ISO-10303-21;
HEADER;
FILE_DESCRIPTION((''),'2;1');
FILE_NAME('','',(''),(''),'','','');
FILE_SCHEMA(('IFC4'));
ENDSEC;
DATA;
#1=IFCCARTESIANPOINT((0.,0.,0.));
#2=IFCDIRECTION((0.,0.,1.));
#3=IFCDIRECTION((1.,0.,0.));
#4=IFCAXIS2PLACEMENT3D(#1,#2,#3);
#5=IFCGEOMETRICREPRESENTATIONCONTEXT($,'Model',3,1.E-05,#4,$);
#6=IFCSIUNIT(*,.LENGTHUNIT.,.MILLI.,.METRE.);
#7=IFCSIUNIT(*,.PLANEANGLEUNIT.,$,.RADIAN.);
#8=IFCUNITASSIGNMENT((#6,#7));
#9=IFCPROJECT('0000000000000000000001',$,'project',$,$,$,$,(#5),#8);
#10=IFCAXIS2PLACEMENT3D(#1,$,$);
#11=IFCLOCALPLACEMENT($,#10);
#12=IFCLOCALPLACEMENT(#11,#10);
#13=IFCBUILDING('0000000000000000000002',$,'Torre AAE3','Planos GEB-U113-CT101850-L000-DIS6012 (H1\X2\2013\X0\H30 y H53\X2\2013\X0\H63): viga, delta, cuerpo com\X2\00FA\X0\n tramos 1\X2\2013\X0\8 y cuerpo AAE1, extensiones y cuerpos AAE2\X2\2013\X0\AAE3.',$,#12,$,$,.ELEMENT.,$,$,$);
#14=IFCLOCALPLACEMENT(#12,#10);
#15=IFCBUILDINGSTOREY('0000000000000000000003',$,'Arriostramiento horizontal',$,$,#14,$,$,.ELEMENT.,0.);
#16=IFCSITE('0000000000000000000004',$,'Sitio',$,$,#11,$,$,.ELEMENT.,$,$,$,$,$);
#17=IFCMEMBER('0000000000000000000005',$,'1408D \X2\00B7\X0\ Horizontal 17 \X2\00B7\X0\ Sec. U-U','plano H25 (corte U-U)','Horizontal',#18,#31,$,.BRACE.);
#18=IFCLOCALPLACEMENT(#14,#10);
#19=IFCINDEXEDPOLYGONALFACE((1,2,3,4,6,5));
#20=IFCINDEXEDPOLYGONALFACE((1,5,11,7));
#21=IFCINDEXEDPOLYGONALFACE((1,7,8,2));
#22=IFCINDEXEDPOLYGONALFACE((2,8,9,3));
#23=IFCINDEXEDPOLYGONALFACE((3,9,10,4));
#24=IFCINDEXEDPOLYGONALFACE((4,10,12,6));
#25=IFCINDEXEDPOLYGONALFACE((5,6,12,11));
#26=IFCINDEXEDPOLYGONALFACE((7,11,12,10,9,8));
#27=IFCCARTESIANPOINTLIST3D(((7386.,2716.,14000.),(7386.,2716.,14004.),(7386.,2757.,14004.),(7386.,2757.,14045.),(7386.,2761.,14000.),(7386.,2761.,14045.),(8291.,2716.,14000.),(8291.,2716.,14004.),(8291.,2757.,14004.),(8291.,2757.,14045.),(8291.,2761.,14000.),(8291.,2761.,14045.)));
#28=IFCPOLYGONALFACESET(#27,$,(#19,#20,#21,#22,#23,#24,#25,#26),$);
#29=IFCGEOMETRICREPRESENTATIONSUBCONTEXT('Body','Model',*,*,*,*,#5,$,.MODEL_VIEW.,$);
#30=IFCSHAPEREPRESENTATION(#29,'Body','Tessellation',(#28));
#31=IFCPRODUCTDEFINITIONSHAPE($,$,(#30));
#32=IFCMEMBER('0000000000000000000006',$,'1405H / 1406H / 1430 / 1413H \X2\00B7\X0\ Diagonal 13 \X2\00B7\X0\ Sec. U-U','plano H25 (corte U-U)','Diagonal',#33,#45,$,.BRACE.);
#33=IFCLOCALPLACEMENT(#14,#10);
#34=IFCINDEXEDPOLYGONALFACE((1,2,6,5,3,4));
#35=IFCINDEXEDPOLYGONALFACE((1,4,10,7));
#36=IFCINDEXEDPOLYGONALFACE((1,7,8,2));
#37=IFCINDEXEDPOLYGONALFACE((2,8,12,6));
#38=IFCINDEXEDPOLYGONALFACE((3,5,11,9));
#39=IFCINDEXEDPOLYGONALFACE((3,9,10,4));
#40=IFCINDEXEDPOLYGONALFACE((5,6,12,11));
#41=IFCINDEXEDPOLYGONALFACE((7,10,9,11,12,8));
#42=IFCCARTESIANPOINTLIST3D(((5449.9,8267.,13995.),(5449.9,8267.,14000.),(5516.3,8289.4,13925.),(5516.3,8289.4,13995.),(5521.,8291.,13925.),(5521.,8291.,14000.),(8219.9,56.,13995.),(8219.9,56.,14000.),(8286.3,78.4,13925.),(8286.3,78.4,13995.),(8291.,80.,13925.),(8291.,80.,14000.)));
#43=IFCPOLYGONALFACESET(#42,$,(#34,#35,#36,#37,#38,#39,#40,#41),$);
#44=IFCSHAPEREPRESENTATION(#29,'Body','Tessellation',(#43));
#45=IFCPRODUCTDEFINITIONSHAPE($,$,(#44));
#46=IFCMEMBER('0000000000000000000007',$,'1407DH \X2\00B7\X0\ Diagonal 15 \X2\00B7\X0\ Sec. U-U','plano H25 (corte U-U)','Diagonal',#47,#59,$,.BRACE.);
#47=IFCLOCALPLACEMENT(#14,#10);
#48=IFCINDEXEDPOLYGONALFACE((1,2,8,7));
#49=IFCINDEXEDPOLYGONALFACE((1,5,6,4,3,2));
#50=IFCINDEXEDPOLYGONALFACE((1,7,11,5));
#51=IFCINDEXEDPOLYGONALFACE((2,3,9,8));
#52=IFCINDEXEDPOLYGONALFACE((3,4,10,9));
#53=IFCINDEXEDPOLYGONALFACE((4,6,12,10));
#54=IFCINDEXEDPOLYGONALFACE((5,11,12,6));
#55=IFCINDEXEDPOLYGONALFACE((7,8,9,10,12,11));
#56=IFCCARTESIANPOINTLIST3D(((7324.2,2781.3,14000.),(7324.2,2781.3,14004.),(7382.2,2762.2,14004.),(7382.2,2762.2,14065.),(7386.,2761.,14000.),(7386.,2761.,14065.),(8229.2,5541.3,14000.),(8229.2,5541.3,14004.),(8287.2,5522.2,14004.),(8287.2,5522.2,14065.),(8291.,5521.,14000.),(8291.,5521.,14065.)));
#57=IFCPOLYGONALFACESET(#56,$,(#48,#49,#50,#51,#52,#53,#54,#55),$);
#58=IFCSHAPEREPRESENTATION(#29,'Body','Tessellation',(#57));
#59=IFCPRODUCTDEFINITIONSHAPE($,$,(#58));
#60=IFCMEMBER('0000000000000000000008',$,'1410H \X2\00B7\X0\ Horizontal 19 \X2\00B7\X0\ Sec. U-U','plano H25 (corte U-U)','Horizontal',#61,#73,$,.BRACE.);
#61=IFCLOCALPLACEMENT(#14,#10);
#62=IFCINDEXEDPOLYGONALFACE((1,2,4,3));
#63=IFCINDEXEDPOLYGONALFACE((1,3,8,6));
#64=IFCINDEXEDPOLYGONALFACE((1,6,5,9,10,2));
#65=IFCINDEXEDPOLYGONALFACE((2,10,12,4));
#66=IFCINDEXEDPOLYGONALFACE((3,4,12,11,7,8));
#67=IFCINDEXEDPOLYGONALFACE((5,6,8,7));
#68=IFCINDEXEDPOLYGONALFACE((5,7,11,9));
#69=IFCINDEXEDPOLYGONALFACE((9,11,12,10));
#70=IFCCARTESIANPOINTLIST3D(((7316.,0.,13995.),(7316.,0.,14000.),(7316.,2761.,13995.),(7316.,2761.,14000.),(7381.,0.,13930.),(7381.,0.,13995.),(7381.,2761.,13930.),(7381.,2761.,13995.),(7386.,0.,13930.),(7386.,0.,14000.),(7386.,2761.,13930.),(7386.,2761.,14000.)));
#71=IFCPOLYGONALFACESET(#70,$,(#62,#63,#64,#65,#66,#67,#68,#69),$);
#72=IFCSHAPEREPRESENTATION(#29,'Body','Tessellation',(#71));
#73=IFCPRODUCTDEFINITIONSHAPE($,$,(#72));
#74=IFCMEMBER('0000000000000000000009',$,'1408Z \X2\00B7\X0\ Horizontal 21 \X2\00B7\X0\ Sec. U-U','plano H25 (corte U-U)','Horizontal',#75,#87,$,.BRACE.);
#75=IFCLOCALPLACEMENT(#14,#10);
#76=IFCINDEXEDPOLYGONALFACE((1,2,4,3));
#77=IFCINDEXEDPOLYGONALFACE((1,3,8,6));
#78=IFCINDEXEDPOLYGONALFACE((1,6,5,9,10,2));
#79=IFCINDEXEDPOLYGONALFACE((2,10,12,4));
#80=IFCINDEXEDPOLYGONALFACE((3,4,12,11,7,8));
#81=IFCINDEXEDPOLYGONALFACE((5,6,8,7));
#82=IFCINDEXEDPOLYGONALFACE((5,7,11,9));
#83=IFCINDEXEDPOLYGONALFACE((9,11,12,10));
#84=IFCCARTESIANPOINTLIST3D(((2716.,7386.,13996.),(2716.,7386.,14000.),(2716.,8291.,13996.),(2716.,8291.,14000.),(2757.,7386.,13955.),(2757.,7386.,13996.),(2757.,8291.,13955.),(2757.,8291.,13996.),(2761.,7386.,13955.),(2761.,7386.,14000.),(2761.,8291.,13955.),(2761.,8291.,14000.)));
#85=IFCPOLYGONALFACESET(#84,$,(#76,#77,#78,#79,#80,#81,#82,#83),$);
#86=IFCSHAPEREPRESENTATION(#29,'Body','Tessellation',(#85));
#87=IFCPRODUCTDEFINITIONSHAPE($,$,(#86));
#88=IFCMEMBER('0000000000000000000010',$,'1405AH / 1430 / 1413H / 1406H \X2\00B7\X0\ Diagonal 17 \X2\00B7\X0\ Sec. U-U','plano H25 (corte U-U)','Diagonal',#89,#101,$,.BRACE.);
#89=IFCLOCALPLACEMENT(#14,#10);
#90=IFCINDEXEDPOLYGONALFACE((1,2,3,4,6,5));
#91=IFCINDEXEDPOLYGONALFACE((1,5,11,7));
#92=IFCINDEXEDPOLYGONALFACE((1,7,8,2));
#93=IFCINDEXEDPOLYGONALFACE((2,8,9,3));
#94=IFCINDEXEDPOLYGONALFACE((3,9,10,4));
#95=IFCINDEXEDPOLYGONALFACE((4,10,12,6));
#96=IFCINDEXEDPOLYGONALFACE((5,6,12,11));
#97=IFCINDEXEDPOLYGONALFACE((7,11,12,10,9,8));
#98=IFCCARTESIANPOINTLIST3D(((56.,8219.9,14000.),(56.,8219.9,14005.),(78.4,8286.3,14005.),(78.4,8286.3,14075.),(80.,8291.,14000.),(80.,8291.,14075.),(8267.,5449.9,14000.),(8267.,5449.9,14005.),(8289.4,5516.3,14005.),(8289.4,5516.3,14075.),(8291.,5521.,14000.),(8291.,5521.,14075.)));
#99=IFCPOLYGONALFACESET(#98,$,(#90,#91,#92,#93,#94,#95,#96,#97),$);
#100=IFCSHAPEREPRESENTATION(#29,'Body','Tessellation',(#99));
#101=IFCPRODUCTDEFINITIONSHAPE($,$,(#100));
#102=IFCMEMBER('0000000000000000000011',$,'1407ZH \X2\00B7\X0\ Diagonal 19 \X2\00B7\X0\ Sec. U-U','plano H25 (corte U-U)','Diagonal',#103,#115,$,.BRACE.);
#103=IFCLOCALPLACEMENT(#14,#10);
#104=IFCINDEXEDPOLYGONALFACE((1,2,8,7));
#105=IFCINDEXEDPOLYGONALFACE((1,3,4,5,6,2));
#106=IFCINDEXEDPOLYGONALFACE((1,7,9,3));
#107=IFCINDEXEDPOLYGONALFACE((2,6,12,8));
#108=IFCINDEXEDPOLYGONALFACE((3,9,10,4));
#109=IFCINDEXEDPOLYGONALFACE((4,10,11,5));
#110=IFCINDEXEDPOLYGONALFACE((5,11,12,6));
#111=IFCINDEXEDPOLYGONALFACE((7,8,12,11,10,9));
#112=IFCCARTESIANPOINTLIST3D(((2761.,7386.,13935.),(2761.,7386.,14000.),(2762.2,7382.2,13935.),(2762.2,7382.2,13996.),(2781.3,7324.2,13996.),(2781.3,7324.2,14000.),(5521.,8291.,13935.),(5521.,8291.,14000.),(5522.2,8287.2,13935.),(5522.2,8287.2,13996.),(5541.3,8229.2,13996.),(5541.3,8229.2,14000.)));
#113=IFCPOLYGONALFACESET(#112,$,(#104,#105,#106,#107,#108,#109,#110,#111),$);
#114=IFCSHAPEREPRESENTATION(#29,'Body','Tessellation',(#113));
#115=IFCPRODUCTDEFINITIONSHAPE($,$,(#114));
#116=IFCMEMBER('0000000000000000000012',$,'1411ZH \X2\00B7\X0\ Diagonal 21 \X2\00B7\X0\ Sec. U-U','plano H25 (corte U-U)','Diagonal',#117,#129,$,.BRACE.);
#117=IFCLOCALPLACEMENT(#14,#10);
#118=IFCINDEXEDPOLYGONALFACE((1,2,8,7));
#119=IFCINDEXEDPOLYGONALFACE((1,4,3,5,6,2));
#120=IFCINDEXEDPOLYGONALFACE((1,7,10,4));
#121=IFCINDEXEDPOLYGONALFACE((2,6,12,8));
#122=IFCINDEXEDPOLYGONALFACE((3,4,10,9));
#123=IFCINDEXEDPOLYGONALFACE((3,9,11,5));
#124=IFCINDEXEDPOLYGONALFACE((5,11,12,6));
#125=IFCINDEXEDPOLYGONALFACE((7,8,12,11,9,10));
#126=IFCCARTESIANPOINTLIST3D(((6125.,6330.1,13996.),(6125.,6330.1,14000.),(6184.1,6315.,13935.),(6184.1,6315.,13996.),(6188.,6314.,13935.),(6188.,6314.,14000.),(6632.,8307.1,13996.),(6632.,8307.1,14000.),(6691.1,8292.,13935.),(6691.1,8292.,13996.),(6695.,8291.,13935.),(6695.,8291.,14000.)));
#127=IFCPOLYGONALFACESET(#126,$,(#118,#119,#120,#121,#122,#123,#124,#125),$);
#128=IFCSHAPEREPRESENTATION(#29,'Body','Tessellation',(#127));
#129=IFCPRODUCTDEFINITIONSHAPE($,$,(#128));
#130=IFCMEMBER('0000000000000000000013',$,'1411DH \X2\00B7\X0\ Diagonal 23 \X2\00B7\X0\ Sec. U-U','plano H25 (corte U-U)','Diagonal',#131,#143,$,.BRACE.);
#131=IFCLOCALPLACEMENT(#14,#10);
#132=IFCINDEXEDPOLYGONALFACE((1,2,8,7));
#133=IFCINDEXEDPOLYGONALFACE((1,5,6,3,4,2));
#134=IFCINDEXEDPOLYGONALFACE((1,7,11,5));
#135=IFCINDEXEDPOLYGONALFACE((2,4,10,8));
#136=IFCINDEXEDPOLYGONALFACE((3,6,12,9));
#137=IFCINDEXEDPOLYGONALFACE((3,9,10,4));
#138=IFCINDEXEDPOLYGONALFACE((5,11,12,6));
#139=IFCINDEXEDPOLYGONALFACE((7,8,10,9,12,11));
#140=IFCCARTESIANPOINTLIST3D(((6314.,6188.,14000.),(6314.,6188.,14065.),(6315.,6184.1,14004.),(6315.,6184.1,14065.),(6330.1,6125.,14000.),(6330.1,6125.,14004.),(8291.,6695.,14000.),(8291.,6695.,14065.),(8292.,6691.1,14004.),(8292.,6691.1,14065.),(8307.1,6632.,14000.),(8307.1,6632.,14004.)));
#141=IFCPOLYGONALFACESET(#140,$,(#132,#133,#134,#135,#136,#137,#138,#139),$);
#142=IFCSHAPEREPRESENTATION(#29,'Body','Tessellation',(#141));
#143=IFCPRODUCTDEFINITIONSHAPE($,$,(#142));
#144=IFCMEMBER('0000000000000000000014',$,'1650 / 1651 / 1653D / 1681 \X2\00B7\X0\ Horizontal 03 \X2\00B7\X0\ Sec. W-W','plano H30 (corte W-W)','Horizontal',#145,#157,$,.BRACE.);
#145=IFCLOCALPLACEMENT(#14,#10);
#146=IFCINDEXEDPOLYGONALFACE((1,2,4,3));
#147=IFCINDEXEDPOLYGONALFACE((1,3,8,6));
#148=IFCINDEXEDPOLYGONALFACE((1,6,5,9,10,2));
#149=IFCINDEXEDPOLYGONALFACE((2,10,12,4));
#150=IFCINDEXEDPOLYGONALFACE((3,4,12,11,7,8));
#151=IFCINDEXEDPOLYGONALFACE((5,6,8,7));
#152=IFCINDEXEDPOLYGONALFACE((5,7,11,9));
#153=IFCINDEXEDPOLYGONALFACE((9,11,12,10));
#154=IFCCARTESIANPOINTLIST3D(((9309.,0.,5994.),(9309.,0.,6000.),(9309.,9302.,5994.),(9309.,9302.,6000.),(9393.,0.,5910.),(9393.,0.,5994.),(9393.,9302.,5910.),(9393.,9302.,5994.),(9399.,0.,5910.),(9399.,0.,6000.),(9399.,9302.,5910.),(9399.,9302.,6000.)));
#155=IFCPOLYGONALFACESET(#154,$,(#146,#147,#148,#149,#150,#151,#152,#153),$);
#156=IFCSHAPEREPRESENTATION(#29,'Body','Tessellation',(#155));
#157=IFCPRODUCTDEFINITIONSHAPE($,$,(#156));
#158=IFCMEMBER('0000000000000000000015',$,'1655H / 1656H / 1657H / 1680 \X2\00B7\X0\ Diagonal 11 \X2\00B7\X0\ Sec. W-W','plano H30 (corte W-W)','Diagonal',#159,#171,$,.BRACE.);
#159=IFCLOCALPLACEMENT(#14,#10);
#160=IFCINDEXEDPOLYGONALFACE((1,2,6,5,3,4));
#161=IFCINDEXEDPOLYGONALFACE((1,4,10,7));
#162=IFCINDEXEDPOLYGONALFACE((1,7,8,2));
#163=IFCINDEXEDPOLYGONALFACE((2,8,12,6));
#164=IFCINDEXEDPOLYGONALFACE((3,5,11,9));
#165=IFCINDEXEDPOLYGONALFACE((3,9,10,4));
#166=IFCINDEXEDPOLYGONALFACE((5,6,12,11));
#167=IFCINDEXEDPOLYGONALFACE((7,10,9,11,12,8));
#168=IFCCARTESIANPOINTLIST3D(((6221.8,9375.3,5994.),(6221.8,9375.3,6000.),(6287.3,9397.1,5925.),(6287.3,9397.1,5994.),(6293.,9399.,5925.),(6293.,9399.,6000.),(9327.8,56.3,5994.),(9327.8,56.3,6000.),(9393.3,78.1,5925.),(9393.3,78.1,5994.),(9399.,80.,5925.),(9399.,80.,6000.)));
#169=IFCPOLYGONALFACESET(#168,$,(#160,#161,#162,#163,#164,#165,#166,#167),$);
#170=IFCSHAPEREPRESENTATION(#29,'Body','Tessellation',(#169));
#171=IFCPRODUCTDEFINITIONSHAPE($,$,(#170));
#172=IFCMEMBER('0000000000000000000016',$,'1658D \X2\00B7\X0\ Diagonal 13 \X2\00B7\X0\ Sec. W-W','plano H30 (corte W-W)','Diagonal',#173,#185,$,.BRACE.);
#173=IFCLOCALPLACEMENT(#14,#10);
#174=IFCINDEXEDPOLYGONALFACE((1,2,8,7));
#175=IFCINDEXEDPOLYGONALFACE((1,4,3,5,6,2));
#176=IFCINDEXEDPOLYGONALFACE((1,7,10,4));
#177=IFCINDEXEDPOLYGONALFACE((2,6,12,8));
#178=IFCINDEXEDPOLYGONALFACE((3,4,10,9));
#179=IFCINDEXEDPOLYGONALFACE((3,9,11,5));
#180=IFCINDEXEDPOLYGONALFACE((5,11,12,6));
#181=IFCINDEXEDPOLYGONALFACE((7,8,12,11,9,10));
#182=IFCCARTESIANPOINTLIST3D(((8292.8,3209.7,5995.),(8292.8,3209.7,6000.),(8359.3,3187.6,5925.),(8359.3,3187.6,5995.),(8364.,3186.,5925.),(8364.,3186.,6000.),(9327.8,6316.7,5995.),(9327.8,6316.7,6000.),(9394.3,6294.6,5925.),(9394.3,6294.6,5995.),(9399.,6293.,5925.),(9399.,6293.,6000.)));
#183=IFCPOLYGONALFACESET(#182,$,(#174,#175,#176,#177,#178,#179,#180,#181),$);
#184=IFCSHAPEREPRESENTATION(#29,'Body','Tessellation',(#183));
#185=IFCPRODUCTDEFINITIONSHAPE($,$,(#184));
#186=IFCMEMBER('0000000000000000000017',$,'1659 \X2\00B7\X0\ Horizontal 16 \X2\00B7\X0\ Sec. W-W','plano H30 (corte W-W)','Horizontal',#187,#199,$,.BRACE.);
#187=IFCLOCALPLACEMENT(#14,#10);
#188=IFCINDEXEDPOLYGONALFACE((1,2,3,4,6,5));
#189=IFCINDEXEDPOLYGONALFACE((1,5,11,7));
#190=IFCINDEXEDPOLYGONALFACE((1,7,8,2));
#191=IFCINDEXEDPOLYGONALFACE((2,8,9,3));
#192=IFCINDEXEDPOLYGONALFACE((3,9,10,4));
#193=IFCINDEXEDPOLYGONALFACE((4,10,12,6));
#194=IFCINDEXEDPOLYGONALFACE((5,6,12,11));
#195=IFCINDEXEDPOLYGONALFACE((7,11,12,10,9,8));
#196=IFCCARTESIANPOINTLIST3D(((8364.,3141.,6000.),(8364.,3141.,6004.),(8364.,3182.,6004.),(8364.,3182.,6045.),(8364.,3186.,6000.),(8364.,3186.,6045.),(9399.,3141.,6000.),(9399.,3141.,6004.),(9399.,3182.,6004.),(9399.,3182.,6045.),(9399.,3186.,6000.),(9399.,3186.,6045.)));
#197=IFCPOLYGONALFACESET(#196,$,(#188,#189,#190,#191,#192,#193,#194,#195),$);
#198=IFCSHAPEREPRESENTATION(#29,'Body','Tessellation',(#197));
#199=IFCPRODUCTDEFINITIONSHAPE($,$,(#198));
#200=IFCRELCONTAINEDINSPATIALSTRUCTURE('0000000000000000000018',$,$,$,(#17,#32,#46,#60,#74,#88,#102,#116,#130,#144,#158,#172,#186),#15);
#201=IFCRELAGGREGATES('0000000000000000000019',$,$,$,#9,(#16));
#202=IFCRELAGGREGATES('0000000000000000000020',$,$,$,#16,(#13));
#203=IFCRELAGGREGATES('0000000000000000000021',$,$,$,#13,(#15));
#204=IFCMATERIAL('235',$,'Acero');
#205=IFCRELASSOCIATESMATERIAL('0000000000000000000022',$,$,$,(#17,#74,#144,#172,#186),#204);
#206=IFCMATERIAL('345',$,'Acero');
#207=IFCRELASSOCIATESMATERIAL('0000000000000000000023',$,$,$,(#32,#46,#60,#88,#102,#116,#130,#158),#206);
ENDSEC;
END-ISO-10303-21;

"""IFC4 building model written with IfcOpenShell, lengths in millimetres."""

from ifc_helpers import new_model, si_unit, frame, frame_2d, origin, origin_with_axes, place, context, subcontext, project, spatial, l_section, extrude, material, element, save


model = new_model("IFC4")

# Units and contexts
model_context = context("Model", 3, precision=1e-05, world=origin_with_axes())
body_context = subcontext(model_context, "Body", "Model", "MODEL_VIEW")
ifc_project = project(units=[si_unit("LENGTHUNIT", "METRE", prefix="MILLI"), si_unit("PLANEANGLEUNIT", "RADIAN")], contexts=[model_context])

# Site, building, storey
site_placement = place(None, origin())
site = spatial("IfcSite", under=ifc_project, at=site_placement, Name="Sitio", CompositionType="ELEMENT")
building_placement = place(site_placement, origin())
building = spatial("IfcBuilding", under=site, at=building_placement, Name="Torre AAE3", Description="Planos GEB-U113-CT101850-L000-DIS6012 (H1–H30 y H53–H63): viga, delta, cuerpo común tramos 1–8 y cuerpo AAE1, extensiones y cuerpos AAE2–AAE3.", CompositionType="ELEMENT")
storey_placement = place(building_placement, origin())
storey = spatial("IfcBuildingStorey", under=building, at=storey_placement, Name="Arriostramiento horizontal", CompositionType="ELEMENT", Elevation=0.0)

# Members
ifc_material_1 = material(Name="235", Category="Acero")
ifc_material_2 = material(Name="345", Category="Acero")
member_1_placement = place(storey_placement, frame((8291.0, 2761.0, 14000.0), z_axis=(-1.0, 0.0, 0.0), x_axis=(0.0, -1.0, 0.0)))
element("IfcMember", 1, at=member_1_placement, inside=storey, material=ifc_material_1, Name="1408D · Horizontal 17 · Sec. U-U", Description="plano H25 (corte U-U)", ObjectType="Horizontal", PredefinedType="BRACE", context=body_context, shape_type="SweptSolid", body=[
    extrude(l_section(Depth=45.0, Width=45.0, Thickness=4.0, at=frame_2d((22.5, 22.5))), None, (0.0, 0.0, 1.0), 905.0),
])
member_2_placement = place(storey_placement, frame((5521.0, 8291.0, 14000.0), z_axis=(0.319653, -0.947535, 0.0), x_axis=(-0.947535, -0.319653, 0.0)))
element("IfcMember", 2, at=member_2_placement, inside=storey, material=ifc_material_2, Name="1405H / 1406H / 1430 / 1413H · Diagonal 13 · Sec. U-U", Description="plano H25 (corte U-U)", ObjectType="Diagonal", PredefinedType="BRACE", context=body_context, shape_type="SweptSolid", body=[
    extrude(l_section(Depth=75.0, Width=75.0, Thickness=5.0, at=frame_2d((37.5, 37.5))), None, (0.0, 0.0, 1.0), 8665.6),
])
member_3_placement = place(storey_placement, frame((7386.0, 2761.0, 14000.0), z_axis=(0.311576, 0.950221, 0.0), x_axis=(-0.950221, 0.311576, 0.0)))
element("IfcMember", 3, at=member_3_placement, inside=storey, material=ifc_material_2, Name="1407DH · Diagonal 15 · Sec. U-U", Description="plano H25 (corte U-U)", ObjectType="Diagonal", PredefinedType="BRACE", context=body_context, shape_type="SweptSolid", body=[
    extrude(l_section(Depth=65.0, Width=65.0, Thickness=4.0, at=frame_2d((32.5, 32.5))), None, (0.0, 0.0, 1.0), 2904.6),
])
member_4_placement = place(storey_placement, frame((7386.0, 2761.0, 14000.0), z_axis=(0.0, -1.0, 0.0), x_axis=(-1.0, 0.0, 0.0)))
element("IfcMember", 4, at=member_4_placement, inside=storey, material=ifc_material_2, Name="1410H · Horizontal 19 · Sec. U-U", Description="plano H25 (corte U-U)", ObjectType="Horizontal", PredefinedType="BRACE", context=body_context, shape_type="SweptSolid", body=[
    extrude(l_section(Depth=70.0, Width=70.0, Thickness=5.0, at=frame_2d((35.0, 35.0))), None, (0.0, 0.0, 1.0), 2761.0),
])
member_5_placement = place(storey_placement, frame((2761.0, 8291.0, 14000.0), z_axis=(0.0, -1.0, 0.0), x_axis=(-1.0, 0.0, 0.0)))
element("IfcMember", 5, at=member_5_placement, inside=storey, material=ifc_material_1, Name="1408Z · Horizontal 21 · Sec. U-U", Description="plano H25 (corte U-U)", ObjectType="Horizontal", PredefinedType="BRACE", context=body_context, shape_type="SweptSolid", body=[
    extrude(l_section(Depth=45.0, Width=45.0, Thickness=4.0, at=frame_2d((22.5, 22.5))), None, (0.0, 0.0, 1.0), 905.0),
])
member_6_placement = place(storey_placement, frame((8291.0, 5521.0, 14000.0), z_axis=(-0.947535, 0.319653, 0.0), x_axis=(-0.319653, -0.947535, 0.0)))
element("IfcMember", 6, at=member_6_placement, inside=storey, material=ifc_material_2, Name="1405AH / 1430 / 1413H / 1406H · Diagonal 17 · Sec. U-U", Description="plano H25 (corte U-U)", ObjectType="Diagonal", PredefinedType="BRACE", context=body_context, shape_type="SweptSolid", body=[
    extrude(l_section(Depth=75.0, Width=75.0, Thickness=5.0, at=frame_2d((37.5, 37.5))), None, (0.0, 0.0, 1.0), 8665.6),
])
member_7_placement = place(storey_placement, frame((2761.0, 7386.0, 14000.0), z_axis=(0.950221, 0.311576, 0.0), x_axis=(0.311576, -0.950221, 0.0)))
element("IfcMember", 7, at=member_7_placement, inside=storey, material=ifc_material_2, Name="1407ZH · Diagonal 19 · Sec. U-U", Description="plano H25 (corte U-U)", ObjectType="Diagonal", PredefinedType="BRACE", context=body_context, shape_type="SweptSolid", body=[
    extrude(l_section(Depth=65.0, Width=65.0, Thickness=4.0, at=frame_2d((32.5, 32.5))), None, (0.0, 0.0, 1.0), 2904.6),
])
for number, where, z_axis, x_axis, name in (
    (8, (6695.0, 8291.0, 14000.0), (-0.248411, -0.968655, 0.0), (-0.968655, 0.248411, 0.0), "1411ZH · Diagonal 21 · Sec. U-U"),
    (9, (8291.0, 6695.0, 14000.0), (-0.968655, -0.248411, 0.0), (0.248411, -0.968655, 0.0), "1411DH · Diagonal 23 · Sec. U-U"),
):
    element("IfcMember", number, at=place(storey_placement, frame(where, z_axis=z_axis, x_axis=x_axis)), inside=storey, material=ifc_material_2, Name=name, Description="plano H25 (corte U-U)", ObjectType="Diagonal", PredefinedType="BRACE", context=body_context, shape_type="SweptSolid", body=[
        extrude(l_section(Depth=65.0, Width=65.0, Thickness=4.0, at=frame_2d((32.5, 32.5))), None, (0.0, 0.0, 1.0), 2041.0),
    ])
member_8_placement = place(storey_placement, frame((9399.0, 9302.0, 6000.0), z_axis=(0.0, -1.0, 0.0), x_axis=(-1.0, 0.0, 0.0)))
element("IfcMember", 10, at=member_8_placement, inside=storey, material=ifc_material_1, Name="1650 / 1651 / 1653D / 1681 · Horizontal 03 · Sec. W-W", Description="plano H30 (corte W-W)", ObjectType="Horizontal", PredefinedType="BRACE", context=body_context, shape_type="SweptSolid", body=[
    extrude(l_section(Depth=90.0, Width=90.0, Thickness=6.0, at=frame_2d((45.0, 45.0))), None, (0.0, 0.0, 1.0), 9302.0),
])
member_9_placement = place(storey_placement, frame((6293.0, 9399.0, 6000.0), z_axis=(0.316197, -0.948693, 0.0), x_axis=(-0.948693, -0.316197, 0.0)))
element("IfcMember", 11, at=member_9_placement, inside=storey, material=ifc_material_2, Name="1655H / 1656H / 1657H / 1680 · Diagonal 11 · Sec. W-W", Description="plano H30 (corte W-W)", ObjectType="Diagonal", PredefinedType="BRACE", context=body_context, shape_type="SweptSolid", body=[
    extrude(l_section(Depth=75.0, Width=75.0, Thickness=6.0, at=frame_2d((37.5, 37.5))), None, (0.0, 0.0, 1.0), 9823.0),
])
member_10_placement = place(storey_placement, frame((9399.0, 6293.0, 6000.0), z_axis=(-0.316045, -0.948744, 0.0), x_axis=(-0.948744, 0.316045, 0.0)))
element("IfcMember", 12, at=member_10_placement, inside=storey, material=ifc_material_1, Name="1658D · Diagonal 13 · Sec. W-W", Description="plano H30 (corte W-W)", ObjectType="Diagonal", PredefinedType="BRACE", context=body_context, shape_type="SweptSolid", body=[
    extrude(l_section(Depth=75.0, Width=75.0, Thickness=5.0, at=frame_2d((37.5, 37.5))), None, (0.0, 0.0, 1.0), 3274.9),
])
for number, where, z_axis, x_axis, name in (
    (13, (9399.0, 3186.0, 6000.0), (-1.0, 0.0, 0.0), (0.0, -1.0, 0.0), "1659 · Horizontal 16 · Sec. W-W"),
):
    element("IfcMember", number, at=place(storey_placement, frame(where, z_axis=z_axis, x_axis=x_axis)), inside=storey, material=ifc_material_1, Name=name, Description="plano H30 (corte W-W)", ObjectType="Horizontal", PredefinedType="BRACE", context=body_context, shape_type="SweptSolid", body=[
        extrude(l_section(Depth=45.0, Width=45.0, Thickness=4.0, at=frame_2d((22.5, 22.5))), None, (0.0, 0.0, 1.0), 1035.0),
    ])

save(model, "model.ifc")
